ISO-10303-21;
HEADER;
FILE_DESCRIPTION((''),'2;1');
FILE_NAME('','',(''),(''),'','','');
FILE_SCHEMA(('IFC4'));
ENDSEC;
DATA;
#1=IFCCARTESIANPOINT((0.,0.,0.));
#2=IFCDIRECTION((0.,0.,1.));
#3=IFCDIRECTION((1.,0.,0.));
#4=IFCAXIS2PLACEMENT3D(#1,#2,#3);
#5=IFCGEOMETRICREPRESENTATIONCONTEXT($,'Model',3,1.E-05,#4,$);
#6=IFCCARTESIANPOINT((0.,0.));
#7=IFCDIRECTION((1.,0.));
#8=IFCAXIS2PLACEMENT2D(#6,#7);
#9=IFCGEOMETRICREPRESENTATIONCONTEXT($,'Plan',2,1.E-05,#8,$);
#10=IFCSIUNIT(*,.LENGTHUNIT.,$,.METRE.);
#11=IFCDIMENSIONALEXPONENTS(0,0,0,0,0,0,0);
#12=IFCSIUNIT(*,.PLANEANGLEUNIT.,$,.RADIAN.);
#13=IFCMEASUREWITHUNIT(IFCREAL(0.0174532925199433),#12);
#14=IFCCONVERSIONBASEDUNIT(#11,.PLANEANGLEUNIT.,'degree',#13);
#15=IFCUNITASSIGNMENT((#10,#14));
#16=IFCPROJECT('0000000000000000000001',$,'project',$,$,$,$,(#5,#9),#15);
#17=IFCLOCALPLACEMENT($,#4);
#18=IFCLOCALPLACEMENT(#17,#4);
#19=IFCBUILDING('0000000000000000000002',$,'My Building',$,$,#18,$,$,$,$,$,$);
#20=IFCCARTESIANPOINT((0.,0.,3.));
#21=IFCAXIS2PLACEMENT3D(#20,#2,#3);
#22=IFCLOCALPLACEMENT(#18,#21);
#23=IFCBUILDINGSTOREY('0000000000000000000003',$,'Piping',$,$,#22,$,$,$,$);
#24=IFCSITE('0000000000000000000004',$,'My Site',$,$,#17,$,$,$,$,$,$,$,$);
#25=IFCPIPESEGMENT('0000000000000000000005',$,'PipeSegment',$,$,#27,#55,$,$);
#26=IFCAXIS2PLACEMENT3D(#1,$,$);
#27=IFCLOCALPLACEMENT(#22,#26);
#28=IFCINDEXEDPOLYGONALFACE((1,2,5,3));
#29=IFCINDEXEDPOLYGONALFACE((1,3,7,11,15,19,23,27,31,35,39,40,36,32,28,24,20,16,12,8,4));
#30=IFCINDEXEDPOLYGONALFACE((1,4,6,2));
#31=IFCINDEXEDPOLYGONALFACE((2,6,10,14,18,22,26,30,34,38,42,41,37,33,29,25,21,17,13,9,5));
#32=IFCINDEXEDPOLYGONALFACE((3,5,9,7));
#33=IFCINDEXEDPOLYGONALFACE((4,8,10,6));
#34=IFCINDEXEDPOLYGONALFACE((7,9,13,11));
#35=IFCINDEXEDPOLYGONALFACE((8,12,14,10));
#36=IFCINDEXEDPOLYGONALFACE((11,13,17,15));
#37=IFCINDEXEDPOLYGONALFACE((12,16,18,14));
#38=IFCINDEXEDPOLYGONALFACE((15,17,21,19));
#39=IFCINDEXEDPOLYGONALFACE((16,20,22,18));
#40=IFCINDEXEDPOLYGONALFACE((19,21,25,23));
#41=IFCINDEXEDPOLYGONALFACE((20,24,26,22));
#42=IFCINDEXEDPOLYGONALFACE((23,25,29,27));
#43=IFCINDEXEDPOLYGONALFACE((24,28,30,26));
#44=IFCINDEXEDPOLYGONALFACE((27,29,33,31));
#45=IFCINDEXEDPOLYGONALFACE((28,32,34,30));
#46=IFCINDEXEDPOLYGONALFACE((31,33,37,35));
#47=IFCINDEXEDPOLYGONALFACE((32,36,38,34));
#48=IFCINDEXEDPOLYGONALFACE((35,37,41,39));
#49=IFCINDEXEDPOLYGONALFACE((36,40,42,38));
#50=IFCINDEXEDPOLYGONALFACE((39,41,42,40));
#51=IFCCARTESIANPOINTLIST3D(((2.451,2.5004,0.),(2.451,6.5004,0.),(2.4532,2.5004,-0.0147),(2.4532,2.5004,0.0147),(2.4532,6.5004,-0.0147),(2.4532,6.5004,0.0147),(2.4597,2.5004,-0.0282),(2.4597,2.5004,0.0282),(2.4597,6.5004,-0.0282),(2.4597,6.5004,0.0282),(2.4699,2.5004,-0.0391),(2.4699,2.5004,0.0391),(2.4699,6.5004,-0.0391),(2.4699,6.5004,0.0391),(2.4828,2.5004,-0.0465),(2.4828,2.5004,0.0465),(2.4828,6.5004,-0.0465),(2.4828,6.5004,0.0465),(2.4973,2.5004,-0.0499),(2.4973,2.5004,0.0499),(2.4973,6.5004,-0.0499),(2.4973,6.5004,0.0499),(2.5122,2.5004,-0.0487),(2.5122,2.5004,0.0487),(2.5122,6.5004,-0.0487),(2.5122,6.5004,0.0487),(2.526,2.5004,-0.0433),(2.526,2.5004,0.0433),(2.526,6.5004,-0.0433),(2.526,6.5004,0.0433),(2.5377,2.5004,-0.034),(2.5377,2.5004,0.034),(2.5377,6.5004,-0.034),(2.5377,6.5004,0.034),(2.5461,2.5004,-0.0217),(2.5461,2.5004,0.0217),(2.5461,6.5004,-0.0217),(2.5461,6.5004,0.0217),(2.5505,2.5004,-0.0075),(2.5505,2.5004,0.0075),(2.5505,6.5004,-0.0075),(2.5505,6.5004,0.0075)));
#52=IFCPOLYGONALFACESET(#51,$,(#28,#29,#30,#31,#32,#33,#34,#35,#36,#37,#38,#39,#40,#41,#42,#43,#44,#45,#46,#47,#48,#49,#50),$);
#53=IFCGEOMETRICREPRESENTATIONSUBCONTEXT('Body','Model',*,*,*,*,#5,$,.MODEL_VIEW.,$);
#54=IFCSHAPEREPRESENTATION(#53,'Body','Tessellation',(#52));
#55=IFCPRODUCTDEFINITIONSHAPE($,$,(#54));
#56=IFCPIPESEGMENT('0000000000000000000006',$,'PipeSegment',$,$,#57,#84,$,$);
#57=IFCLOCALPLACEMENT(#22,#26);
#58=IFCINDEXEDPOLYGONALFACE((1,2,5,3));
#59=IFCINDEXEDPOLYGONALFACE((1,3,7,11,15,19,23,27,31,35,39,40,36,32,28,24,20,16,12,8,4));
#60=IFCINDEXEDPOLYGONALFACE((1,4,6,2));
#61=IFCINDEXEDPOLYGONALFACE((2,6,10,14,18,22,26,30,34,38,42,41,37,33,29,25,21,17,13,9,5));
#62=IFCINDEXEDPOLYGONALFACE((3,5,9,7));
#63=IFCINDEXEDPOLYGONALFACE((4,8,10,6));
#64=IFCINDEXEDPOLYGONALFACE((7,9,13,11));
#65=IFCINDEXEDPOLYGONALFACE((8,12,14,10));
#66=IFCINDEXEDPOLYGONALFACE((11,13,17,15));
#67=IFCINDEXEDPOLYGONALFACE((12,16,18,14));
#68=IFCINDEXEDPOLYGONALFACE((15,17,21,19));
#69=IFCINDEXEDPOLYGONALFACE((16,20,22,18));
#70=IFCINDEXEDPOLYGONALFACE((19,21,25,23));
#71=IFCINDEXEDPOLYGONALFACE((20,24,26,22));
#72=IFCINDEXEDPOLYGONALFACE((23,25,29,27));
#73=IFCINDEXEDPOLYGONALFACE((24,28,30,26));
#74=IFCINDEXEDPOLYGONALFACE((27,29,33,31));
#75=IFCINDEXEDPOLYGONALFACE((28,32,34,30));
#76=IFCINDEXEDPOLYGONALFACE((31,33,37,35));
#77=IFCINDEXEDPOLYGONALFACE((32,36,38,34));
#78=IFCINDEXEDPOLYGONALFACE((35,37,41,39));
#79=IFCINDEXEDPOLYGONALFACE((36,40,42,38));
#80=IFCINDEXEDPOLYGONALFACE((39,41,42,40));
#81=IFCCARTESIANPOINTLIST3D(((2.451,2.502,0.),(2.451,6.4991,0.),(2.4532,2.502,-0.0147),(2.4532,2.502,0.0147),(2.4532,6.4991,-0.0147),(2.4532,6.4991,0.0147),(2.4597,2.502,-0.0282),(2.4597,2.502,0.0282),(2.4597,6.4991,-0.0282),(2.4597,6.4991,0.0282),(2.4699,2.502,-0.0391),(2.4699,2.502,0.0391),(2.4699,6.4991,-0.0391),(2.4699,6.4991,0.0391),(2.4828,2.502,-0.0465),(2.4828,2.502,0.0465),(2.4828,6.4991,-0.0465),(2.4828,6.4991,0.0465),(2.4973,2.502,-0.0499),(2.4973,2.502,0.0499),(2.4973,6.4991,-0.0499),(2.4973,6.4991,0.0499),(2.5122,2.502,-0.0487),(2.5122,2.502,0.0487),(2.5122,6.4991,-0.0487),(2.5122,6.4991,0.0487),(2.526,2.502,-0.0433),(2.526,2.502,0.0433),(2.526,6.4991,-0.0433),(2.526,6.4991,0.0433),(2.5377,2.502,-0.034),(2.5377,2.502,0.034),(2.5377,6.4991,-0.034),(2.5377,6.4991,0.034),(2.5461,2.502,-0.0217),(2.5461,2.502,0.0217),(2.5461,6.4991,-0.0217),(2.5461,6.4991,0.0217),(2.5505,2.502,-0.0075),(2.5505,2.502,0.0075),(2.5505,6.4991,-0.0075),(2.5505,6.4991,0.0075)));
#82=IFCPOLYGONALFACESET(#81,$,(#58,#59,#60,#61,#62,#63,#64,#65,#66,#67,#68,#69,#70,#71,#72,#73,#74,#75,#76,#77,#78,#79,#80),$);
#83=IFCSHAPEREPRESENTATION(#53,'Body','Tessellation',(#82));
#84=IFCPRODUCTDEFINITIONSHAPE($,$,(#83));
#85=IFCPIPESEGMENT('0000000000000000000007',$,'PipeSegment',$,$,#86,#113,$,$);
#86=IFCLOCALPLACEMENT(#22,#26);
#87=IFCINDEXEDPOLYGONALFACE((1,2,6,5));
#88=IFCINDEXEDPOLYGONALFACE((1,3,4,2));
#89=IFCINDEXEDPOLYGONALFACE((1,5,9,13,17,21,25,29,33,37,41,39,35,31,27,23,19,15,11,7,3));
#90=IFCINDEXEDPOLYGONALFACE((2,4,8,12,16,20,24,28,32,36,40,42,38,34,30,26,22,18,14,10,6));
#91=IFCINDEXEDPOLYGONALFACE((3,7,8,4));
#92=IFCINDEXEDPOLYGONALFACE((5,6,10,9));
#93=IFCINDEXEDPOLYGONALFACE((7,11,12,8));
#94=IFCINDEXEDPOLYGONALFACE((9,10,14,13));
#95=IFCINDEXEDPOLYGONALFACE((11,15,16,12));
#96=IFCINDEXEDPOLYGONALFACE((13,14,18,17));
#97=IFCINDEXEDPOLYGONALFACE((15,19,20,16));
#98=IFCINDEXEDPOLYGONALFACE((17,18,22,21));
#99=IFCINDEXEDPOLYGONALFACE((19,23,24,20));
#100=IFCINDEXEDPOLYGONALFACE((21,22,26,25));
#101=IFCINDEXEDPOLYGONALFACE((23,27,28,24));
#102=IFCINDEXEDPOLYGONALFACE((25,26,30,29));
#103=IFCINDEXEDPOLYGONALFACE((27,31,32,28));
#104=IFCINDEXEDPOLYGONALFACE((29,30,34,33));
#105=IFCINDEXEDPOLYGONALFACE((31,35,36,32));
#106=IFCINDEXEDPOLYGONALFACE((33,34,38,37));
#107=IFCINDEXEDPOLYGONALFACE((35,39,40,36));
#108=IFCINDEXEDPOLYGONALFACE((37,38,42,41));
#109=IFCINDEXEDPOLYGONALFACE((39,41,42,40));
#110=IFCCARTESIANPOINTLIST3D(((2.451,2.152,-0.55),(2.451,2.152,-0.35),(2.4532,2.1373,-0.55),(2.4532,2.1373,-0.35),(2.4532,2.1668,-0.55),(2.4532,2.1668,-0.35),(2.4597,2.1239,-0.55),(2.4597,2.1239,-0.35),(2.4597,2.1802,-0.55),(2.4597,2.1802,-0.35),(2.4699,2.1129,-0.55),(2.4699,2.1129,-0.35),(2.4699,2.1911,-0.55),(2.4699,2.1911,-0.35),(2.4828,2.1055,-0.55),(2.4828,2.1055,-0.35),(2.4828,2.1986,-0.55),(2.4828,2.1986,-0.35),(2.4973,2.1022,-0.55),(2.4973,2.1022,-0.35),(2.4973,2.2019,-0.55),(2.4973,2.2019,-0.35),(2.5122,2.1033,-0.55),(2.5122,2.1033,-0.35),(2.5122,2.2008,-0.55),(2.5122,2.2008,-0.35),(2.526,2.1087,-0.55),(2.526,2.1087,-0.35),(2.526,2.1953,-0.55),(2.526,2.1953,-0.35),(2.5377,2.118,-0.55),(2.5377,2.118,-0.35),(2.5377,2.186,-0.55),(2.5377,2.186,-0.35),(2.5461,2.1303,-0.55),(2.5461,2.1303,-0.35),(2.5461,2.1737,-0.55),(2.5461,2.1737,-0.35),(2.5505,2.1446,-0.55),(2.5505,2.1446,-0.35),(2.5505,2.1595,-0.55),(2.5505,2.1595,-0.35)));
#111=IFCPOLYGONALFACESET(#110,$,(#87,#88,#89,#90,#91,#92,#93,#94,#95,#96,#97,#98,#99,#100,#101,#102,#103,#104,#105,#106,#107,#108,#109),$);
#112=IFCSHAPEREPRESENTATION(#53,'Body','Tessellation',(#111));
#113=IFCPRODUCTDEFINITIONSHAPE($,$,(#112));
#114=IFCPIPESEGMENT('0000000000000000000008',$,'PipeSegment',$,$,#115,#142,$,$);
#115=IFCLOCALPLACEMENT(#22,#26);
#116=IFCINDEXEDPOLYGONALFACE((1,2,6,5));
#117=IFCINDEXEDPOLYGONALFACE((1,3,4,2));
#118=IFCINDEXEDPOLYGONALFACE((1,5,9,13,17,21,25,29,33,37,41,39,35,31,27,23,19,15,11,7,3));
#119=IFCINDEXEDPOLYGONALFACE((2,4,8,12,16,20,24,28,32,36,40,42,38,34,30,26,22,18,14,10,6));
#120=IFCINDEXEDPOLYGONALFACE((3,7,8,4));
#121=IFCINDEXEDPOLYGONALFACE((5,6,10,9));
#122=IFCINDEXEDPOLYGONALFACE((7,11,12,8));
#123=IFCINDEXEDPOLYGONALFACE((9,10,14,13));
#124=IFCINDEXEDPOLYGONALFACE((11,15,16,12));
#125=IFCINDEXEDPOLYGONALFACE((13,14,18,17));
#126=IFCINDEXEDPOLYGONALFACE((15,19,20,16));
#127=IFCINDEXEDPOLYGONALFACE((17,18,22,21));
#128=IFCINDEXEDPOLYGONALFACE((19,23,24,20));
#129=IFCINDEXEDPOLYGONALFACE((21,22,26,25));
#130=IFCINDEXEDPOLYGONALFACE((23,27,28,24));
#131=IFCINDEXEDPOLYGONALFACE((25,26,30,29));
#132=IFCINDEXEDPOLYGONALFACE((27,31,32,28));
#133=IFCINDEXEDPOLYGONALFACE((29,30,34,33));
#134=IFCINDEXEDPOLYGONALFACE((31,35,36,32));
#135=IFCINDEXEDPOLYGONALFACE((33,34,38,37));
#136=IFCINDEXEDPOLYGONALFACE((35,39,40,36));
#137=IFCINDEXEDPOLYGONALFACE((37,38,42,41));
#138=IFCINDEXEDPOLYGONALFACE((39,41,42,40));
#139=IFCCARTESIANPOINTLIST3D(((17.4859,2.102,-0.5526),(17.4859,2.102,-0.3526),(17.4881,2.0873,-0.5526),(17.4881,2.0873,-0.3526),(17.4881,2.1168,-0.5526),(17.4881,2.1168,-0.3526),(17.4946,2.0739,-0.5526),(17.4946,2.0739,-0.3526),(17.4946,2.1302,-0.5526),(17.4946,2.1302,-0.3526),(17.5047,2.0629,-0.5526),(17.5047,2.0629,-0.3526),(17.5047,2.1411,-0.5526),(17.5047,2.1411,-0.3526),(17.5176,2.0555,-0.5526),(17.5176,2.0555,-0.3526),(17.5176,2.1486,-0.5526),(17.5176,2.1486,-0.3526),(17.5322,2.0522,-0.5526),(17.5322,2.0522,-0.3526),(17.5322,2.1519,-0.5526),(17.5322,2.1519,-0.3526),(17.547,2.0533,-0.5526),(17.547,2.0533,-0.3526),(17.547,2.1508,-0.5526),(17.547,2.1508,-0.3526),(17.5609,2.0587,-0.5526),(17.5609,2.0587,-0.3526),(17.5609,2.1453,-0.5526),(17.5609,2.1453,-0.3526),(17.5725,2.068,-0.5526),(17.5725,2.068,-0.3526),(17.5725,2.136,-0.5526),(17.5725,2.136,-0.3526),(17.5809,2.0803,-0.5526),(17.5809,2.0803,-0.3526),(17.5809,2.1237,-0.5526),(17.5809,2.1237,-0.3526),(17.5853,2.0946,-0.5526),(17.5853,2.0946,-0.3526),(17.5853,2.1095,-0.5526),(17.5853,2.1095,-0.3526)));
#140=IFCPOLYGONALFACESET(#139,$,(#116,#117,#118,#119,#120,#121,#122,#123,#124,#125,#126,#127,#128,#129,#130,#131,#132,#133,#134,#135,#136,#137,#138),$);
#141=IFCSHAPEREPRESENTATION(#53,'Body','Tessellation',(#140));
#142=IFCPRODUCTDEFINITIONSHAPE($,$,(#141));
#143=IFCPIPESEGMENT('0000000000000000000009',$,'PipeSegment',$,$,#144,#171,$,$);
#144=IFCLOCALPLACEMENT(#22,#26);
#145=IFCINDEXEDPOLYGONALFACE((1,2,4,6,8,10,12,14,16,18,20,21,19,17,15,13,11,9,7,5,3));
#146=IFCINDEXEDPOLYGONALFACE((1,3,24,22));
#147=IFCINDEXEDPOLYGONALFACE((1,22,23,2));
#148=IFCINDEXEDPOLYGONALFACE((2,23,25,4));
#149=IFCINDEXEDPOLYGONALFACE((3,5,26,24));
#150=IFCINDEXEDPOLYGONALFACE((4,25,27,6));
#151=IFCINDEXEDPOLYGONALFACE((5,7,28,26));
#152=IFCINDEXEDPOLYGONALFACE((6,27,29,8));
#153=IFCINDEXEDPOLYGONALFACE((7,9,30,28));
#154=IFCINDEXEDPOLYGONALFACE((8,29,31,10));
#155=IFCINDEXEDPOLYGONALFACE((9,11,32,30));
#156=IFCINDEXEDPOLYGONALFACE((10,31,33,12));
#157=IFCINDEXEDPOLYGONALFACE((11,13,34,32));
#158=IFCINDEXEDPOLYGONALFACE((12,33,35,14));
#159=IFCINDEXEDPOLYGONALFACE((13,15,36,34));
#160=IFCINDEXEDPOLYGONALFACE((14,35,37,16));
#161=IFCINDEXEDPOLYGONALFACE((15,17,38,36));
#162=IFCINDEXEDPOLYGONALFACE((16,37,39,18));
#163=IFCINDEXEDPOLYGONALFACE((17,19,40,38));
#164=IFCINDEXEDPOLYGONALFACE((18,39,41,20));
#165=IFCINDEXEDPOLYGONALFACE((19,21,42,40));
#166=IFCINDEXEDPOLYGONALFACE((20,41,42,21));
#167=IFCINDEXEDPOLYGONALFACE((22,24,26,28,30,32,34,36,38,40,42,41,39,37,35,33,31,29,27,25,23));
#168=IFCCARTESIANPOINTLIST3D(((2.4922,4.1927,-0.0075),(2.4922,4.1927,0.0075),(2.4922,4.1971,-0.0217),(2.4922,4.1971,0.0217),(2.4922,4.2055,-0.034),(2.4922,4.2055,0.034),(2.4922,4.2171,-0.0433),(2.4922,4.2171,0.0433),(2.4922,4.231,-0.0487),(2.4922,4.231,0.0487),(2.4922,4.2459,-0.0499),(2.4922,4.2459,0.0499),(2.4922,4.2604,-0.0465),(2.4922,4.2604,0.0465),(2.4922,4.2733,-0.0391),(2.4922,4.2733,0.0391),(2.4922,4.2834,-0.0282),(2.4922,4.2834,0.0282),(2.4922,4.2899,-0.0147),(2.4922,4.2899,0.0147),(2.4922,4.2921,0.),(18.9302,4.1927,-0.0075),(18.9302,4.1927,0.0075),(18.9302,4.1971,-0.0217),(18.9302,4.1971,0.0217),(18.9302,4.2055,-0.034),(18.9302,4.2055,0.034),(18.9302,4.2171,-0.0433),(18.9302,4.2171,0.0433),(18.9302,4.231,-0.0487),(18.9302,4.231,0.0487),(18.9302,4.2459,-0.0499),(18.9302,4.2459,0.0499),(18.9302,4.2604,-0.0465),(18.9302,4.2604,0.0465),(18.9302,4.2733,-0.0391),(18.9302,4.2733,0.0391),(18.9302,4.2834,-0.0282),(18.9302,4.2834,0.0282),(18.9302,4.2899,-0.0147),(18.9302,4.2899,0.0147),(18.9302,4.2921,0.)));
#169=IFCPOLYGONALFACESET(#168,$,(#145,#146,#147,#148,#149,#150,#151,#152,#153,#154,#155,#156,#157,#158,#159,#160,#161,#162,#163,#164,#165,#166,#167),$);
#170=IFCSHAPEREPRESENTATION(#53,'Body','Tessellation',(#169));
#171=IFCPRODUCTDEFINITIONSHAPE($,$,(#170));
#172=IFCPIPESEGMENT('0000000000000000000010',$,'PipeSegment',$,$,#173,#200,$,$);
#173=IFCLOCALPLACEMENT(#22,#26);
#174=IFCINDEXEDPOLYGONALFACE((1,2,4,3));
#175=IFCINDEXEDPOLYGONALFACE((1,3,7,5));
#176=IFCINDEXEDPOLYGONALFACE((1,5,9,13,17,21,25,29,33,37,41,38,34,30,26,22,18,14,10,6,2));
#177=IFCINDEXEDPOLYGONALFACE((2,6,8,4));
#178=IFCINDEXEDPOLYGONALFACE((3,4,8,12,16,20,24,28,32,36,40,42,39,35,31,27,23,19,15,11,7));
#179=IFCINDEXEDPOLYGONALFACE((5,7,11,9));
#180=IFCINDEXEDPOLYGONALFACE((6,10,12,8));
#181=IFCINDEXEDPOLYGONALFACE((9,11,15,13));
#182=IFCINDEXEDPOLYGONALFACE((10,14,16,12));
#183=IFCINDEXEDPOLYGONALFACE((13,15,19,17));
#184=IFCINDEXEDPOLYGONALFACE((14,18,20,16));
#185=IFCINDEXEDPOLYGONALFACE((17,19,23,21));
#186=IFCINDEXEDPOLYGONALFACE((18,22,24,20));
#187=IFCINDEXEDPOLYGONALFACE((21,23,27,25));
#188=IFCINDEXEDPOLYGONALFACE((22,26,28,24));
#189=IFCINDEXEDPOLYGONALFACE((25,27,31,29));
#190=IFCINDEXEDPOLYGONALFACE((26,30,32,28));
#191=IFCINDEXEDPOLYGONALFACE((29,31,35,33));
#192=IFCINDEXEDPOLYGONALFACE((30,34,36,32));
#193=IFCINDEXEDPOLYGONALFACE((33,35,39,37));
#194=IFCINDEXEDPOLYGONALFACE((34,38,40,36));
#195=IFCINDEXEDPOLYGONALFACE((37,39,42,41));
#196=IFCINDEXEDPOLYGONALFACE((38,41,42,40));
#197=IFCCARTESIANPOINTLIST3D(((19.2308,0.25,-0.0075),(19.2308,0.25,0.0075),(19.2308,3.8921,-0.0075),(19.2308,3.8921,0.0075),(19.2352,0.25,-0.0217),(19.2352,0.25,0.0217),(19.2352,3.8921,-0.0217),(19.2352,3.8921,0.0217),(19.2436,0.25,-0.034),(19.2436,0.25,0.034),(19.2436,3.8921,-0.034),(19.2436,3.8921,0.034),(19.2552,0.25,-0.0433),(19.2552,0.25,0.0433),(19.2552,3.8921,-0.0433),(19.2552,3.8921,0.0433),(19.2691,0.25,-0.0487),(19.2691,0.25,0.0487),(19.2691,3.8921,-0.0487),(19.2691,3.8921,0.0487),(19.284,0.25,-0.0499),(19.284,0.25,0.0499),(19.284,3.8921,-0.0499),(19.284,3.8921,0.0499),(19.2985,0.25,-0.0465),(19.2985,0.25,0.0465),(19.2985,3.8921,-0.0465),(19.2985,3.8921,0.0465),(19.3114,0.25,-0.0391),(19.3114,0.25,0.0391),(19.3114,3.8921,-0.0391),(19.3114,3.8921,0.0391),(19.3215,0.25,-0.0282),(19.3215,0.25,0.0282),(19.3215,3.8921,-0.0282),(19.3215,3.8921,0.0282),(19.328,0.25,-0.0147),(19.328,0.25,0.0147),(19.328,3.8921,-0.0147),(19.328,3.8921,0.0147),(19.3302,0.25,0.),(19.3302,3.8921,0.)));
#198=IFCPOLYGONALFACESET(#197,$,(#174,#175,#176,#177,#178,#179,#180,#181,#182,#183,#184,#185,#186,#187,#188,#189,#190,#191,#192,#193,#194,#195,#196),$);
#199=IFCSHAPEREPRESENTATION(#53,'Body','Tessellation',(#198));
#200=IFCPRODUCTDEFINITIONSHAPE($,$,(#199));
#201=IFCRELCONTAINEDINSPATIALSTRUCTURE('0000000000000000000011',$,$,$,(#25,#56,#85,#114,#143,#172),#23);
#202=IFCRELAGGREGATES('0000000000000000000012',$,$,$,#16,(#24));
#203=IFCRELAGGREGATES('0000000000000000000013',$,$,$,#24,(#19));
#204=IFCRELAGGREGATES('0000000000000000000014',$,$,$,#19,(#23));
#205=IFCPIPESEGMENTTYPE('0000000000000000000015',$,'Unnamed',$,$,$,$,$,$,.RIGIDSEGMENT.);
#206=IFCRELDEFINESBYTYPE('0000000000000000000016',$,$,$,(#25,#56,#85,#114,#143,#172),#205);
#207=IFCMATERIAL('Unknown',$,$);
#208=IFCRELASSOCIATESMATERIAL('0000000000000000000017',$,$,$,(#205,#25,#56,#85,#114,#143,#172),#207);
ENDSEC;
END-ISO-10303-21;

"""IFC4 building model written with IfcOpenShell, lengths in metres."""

from ifc_helpers import new_model, entity, si_unit, converted_unit, frame, origin_with_axes, origin_2d_with_axis, place, context, subcontext, project, spatial, circle, extrude, material, material_profile, profile_set, profile_usage, type_object, element, save


model = new_model("IFC4")

# Units and contexts
model_context = context("Model", 3, precision=1e-05, world=origin_with_axes())
plan_context = context("Plan", 2, precision=1e-05, world=origin_2d_with_axis())
body_context = subcontext(model_context, "Body", "Model", "MODEL_VIEW")
ifc_project = project(units=[si_unit("LENGTHUNIT", "METRE"), converted_unit("PLANEANGLEUNIT", "degree", entity("IfcReal", 0.0174532925199433), si_unit("PLANEANGLEUNIT", "RADIAN"), dimensions=[0, 0, 0, 0, 0, 0, 0])], contexts=[model_context, plan_context])

# Site, building, storey
site_placement = place(None, origin_with_axes())
site = spatial("IfcSite", under=ifc_project, at=site_placement, Name="My Site")
building_placement = place(site_placement, origin_with_axes())
building = spatial("IfcBuilding", under=site, at=building_placement, Name="My Building")
storey_placement = place(building_placement, frame((0.0, 0.0, 3.0), z_axis=(0.0, 0.0, 1.0), x_axis=(1.0, 0.0, 0.0)))
storey = spatial("IfcBuildingStorey", under=building, at=storey_placement, Name="Piping")

# Pipe segments
ifc_material = material(Name="Unknown")
ifc_material_profile = material_profile(ifc_material, circle(Radius=0.05))
ifc_profile_set = profile_set([ifc_material_profile])
ifc_profile_usage_1 = profile_usage(ifc_profile_set, cardinal=5)
pipe_segment_type = type_object("IfcPipeSegmentType", Name="Unnamed", PredefinedType="RIGIDSEGMENT", material=ifc_profile_set)
pipe_segment_1_placement = place(storey_placement, frame((2.501, 2.5004, 0.0), z_axis=(0.0, 1.0, 0.0), x_axis=(-1.0, 0.0, 0.0)))
element("IfcPipeSegment", 1, at=pipe_segment_1_placement, inside=storey, type_object=pipe_segment_type, material=ifc_profile_usage_1, Name="PipeSegment", context=body_context, shape_type="SweptSolid", body=[
    extrude(circle(Radius=0.05), origin_with_axes(), (0.0, 0.0, 1.0), 4.0),
])
ifc_profile_usage_2 = profile_usage(ifc_profile_set, cardinal=5)
pipe_segment_2_placement = place(storey_placement, frame((2.501, 2.502, 0.0), z_axis=(0.0, 1.0, 0.0), x_axis=(-1.0, 0.0, 0.0)))
element("IfcPipeSegment", 2, at=pipe_segment_2_placement, inside=storey, type_object=pipe_segment_type, material=ifc_profile_usage_2, Name="PipeSegment", context=body_context, shape_type="SweptSolid", body=[
    extrude(circle(Radius=0.05), origin_with_axes(), (0.0, 0.0, 1.0), 3.997),
])
ifc_profile_usage_3 = profile_usage(ifc_profile_set, cardinal=5)
pipe_segment_3_placement = place(storey_placement, frame((2.501, 2.152, -0.35), z_axis=(0.0, 0.0, -1.0), x_axis=(-1.0, 0.0, 0.0)))
element("IfcPipeSegment", 3, at=pipe_segment_3_placement, inside=storey, type_object=pipe_segment_type, material=ifc_profile_usage_3, Name="PipeSegment", context=body_context, shape_type="SweptSolid", body=[
    extrude(circle(Radius=0.05), origin_with_axes(), (0.0, 0.0, 1.0), 0.2),
])
ifc_profile_usage_4 = profile_usage(ifc_profile_set, cardinal=5)
pipe_segment_4_placement = place(storey_placement, frame((17.5359, 2.102, -0.3526), z_axis=(0.0, 0.0, -1.0), x_axis=(-1.0, 0.0, 0.0)))
element("IfcPipeSegment", 4, at=pipe_segment_4_placement, inside=storey, type_object=pipe_segment_type, material=ifc_profile_usage_4, Name="PipeSegment", context=body_context, shape_type="SweptSolid", body=[
    extrude(circle(Radius=0.05), origin_with_axes(), (0.0, 0.0, 1.0), 0.2),
])
ifc_profile_usage_5 = profile_usage(ifc_profile_set, cardinal=5)
pipe_segment_5_placement = place(storey_placement, frame((2.4922, 4.2421, 0.0), z_axis=(1.0, 0.0, 0.0), x_axis=(0.0, 1.0, 0.0)))
element("IfcPipeSegment", 5, at=pipe_segment_5_placement, inside=storey, type_object=pipe_segment_type, material=ifc_profile_usage_5, Name="PipeSegment", context=body_context, shape_type="SweptSolid", body=[
    extrude(circle(Radius=0.05), origin_with_axes(), (0.0, 0.0, 1.0), 16.438),
])
ifc_profile_usage_6 = profile_usage(ifc_profile_set, cardinal=5)
pipe_segment_6_placement = place(storey_placement, frame((19.2802, 3.8921, 0.0), z_axis=(0.0, -1.0, 0.0), x_axis=(1.0, 0.0, 0.0)))
element("IfcPipeSegment", 6, at=pipe_segment_6_placement, inside=storey, type_object=pipe_segment_type, material=ifc_profile_usage_6, Name="PipeSegment", context=body_context, shape_type="SweptSolid", body=[
    extrude(circle(Radius=0.05), origin_with_axes(), (0.0, 0.0, 1.0), 3.6421),
])

save(model, "model.ifc")
